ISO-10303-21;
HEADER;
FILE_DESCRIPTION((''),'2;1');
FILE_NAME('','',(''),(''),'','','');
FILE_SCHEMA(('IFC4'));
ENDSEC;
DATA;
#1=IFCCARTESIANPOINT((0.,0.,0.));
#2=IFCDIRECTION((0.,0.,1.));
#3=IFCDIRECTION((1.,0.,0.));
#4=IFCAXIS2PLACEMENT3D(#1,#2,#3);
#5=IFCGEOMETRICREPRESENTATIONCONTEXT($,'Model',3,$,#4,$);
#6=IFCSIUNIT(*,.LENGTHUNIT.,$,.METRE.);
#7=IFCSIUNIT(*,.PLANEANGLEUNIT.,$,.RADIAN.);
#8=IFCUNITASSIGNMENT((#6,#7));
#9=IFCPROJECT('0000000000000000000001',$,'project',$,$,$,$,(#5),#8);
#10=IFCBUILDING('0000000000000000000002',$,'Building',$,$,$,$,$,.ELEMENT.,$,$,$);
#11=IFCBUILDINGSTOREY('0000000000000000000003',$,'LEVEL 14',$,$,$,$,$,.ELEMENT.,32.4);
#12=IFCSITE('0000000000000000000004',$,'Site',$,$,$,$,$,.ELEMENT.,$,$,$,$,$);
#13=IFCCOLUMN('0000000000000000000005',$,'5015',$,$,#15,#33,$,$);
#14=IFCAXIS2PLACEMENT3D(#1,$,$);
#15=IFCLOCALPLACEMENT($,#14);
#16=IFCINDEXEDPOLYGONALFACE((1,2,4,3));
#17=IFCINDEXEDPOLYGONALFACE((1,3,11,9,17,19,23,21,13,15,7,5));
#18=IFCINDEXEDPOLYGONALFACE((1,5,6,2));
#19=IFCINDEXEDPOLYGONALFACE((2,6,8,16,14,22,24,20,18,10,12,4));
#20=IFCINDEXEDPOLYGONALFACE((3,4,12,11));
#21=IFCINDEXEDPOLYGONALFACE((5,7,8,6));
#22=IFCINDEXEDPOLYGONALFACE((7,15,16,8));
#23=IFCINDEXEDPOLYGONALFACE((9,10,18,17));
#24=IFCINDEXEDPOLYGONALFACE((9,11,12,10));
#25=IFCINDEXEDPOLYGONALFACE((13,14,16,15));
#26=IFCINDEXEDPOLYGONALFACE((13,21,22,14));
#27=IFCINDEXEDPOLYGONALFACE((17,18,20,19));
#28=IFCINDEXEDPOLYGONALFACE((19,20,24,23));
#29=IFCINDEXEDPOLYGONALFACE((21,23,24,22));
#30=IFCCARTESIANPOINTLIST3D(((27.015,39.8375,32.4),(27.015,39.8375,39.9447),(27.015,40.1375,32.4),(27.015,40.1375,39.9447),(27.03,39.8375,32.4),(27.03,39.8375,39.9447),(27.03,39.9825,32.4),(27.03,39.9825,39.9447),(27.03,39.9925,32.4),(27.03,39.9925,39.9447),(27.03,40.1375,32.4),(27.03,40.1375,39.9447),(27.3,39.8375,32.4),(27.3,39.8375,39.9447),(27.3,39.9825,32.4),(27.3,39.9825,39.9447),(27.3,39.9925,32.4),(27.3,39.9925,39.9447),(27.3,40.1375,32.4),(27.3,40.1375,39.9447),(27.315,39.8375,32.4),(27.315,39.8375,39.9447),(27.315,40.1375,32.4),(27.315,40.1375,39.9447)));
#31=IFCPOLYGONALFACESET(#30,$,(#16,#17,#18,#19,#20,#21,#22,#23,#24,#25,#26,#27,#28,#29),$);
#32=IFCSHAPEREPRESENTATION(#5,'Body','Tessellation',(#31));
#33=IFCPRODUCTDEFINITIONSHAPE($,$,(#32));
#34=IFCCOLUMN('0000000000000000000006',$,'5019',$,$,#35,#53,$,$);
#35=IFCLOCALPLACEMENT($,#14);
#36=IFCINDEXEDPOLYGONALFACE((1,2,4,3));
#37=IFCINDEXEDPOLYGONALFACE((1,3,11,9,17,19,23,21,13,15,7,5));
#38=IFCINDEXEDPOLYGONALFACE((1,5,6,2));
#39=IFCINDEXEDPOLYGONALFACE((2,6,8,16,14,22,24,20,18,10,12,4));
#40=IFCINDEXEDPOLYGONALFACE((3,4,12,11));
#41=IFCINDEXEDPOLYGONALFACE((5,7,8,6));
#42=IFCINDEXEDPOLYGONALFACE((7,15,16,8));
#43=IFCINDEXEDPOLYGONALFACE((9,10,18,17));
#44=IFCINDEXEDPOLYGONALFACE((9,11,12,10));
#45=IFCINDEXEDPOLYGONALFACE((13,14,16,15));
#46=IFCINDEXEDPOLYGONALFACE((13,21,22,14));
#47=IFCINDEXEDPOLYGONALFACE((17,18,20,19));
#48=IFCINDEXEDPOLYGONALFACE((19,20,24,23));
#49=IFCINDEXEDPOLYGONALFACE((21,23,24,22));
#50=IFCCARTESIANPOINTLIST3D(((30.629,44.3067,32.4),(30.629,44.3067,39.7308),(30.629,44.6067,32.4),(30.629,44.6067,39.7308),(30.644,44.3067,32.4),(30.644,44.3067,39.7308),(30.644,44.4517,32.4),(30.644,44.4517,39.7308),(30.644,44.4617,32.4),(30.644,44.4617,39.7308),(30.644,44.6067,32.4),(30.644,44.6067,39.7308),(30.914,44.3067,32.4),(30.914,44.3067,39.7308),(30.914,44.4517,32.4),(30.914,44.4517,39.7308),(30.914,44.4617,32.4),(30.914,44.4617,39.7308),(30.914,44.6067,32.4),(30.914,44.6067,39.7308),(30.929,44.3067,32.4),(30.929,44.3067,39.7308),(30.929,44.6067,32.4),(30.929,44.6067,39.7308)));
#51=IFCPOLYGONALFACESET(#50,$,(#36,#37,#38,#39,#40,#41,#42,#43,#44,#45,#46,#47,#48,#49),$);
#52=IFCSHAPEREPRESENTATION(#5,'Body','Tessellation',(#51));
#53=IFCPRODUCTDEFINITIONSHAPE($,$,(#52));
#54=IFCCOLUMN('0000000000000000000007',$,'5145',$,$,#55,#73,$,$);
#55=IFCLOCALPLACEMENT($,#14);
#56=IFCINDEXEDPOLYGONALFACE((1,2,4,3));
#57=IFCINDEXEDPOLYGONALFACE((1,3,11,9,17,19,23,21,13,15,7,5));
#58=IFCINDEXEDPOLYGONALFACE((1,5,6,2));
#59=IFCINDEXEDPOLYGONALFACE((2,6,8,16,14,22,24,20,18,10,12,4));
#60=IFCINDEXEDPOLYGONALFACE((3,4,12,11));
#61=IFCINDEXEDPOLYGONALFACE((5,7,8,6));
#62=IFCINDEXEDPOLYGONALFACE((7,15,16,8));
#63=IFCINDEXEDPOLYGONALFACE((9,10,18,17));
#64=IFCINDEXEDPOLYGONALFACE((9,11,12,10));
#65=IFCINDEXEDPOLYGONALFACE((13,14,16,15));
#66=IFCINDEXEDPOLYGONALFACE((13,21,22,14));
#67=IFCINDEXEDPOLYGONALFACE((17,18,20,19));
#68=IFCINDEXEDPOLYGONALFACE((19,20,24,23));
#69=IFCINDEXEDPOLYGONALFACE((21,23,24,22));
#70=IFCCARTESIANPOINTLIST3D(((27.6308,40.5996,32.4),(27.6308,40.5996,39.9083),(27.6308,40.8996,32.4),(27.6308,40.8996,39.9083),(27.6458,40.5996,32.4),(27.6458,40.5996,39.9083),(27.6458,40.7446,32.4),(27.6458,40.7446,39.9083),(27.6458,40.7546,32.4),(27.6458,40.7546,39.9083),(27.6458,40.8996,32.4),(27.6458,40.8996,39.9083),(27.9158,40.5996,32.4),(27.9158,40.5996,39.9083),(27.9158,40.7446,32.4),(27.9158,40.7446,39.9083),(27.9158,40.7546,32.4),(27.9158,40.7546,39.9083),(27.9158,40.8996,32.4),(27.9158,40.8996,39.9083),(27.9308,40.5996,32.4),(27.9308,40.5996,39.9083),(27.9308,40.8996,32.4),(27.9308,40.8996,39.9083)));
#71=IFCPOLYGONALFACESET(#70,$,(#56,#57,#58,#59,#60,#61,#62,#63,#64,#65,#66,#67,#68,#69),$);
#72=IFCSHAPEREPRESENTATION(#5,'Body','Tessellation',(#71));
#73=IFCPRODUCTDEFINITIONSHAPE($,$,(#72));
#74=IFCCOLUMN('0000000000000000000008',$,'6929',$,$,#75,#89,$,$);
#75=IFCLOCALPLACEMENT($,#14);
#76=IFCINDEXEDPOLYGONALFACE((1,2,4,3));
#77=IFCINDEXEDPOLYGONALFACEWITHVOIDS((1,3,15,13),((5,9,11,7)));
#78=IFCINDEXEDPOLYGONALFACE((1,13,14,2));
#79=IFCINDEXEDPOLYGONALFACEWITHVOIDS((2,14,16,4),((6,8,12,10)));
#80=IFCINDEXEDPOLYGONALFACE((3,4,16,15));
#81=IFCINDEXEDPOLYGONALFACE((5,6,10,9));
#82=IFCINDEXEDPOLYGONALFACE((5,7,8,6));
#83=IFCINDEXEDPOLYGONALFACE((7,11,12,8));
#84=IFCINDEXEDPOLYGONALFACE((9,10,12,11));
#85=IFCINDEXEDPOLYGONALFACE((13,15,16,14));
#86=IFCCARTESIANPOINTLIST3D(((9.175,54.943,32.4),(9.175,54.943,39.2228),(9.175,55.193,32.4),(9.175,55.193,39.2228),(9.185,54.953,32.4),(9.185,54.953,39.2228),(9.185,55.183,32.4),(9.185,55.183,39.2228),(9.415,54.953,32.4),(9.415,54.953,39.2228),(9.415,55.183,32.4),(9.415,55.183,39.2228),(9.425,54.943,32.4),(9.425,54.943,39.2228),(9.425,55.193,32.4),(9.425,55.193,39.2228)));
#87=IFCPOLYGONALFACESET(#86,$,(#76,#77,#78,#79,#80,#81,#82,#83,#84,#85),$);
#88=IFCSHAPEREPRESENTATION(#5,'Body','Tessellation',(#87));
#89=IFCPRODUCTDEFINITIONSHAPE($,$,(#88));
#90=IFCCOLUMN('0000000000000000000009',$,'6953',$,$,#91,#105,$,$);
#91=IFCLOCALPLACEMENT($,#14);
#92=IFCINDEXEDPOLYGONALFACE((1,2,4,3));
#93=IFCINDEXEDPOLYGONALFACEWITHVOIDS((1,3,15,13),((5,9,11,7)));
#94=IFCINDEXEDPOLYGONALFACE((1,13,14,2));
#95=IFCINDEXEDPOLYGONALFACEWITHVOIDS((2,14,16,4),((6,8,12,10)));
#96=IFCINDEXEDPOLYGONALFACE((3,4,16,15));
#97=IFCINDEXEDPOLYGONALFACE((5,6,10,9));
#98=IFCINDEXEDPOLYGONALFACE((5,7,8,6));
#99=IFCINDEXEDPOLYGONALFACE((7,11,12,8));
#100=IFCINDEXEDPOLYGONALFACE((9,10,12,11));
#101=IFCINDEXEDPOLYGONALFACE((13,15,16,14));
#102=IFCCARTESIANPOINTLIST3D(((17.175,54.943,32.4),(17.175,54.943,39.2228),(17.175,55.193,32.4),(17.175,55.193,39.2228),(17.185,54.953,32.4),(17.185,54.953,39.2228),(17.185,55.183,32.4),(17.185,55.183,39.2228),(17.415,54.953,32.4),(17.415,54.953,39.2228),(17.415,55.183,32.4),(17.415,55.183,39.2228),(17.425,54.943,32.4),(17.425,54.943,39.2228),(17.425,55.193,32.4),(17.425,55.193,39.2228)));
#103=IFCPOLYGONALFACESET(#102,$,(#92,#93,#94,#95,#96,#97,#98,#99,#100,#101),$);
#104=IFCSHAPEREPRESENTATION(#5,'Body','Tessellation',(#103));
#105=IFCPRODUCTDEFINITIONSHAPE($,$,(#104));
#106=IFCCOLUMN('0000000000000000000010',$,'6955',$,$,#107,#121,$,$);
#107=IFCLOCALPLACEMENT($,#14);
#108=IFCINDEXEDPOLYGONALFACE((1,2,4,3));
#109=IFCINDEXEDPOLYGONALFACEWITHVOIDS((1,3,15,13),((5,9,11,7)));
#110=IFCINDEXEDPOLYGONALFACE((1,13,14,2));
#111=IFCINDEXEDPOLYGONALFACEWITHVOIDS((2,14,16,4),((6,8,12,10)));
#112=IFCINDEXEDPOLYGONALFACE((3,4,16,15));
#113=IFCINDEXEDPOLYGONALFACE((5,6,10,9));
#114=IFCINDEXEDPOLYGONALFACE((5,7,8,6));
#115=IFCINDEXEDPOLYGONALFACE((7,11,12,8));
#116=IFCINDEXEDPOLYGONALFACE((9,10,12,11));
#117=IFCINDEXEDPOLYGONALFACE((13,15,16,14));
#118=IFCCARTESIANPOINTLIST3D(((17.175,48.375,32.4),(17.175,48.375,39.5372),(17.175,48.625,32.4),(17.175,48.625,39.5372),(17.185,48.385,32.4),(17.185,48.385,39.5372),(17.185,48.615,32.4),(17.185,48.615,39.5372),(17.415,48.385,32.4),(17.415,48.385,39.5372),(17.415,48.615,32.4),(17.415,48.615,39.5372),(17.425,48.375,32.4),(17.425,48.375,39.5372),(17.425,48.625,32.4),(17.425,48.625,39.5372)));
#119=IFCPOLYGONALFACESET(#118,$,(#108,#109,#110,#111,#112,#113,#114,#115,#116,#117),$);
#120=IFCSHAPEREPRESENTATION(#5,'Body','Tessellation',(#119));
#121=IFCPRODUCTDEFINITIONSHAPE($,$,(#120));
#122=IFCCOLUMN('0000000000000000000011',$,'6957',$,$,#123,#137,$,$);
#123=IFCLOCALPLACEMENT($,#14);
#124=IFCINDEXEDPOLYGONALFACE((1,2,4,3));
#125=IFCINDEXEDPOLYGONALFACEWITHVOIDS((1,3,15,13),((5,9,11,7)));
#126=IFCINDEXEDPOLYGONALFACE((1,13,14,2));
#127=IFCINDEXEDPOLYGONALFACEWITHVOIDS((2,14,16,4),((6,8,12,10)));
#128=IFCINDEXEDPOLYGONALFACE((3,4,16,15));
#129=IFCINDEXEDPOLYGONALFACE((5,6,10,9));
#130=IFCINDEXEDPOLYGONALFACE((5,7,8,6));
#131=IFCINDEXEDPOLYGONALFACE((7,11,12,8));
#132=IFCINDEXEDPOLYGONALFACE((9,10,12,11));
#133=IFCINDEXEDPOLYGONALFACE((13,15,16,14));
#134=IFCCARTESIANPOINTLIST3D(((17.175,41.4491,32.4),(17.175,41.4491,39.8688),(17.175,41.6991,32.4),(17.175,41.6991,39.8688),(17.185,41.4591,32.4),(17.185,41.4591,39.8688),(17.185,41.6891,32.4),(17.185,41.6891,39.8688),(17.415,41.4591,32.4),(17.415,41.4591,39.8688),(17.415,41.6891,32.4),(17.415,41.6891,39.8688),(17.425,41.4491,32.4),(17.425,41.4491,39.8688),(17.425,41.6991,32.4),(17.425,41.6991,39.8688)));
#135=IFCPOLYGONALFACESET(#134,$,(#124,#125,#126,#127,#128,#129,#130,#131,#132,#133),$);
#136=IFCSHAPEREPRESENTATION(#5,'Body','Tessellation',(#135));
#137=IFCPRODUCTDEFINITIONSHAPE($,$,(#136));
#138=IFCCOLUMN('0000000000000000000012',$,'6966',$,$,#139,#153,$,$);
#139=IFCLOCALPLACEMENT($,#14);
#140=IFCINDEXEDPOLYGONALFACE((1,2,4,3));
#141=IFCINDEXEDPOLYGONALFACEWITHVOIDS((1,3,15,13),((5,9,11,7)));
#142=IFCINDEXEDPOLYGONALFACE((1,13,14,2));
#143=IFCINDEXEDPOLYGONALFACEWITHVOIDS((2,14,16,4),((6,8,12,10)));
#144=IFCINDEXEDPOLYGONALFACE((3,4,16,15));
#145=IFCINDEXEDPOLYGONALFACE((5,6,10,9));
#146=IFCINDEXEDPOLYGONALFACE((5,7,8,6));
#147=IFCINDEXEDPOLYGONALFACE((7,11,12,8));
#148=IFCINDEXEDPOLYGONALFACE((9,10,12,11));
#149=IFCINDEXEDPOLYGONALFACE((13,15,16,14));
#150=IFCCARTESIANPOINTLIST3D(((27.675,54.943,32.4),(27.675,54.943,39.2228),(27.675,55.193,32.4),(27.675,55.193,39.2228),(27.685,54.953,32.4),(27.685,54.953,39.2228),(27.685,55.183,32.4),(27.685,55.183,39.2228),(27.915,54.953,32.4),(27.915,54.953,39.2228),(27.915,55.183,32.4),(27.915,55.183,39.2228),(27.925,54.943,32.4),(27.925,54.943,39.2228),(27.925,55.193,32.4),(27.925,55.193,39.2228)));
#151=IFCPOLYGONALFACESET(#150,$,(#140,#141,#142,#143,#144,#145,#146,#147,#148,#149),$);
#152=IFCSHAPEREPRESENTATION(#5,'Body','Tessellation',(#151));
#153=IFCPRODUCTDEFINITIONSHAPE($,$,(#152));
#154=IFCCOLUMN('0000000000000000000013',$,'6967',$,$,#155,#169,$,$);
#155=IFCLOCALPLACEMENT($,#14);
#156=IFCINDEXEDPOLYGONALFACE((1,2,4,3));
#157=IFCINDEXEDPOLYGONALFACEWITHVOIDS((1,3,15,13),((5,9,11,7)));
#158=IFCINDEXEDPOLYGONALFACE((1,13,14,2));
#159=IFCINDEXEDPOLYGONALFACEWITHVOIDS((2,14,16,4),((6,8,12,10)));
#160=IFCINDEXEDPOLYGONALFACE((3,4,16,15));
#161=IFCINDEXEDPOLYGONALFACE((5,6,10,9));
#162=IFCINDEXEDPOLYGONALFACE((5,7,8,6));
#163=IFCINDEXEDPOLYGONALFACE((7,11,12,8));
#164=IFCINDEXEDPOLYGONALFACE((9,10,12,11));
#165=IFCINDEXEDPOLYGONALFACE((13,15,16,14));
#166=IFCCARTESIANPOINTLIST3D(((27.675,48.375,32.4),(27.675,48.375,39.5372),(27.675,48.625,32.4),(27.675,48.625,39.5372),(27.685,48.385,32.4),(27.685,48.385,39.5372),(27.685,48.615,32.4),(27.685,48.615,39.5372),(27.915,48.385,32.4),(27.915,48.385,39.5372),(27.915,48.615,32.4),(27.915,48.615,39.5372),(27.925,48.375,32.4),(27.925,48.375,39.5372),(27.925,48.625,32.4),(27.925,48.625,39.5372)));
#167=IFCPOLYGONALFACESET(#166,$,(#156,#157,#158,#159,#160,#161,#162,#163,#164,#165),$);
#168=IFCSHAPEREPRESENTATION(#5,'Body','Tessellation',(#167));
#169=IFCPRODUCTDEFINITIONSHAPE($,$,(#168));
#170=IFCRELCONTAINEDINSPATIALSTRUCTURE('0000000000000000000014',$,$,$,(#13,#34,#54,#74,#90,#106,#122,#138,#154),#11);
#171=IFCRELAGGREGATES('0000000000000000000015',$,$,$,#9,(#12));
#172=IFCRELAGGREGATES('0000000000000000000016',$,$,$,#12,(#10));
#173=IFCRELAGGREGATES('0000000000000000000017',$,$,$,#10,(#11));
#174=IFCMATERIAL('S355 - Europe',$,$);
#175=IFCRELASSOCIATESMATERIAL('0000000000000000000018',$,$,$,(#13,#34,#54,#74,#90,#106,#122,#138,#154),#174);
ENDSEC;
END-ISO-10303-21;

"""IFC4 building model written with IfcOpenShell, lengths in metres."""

from ifc_helpers import new_model, si_unit, frame, origin_with_axes, origin_2d_with_axis, place, context, project, spatial, hollow_rectangle, i_section, extrude, material, material_profile, profile_set, profile_usage, element, save


model = new_model("IFC4")

# Units and contexts
model_context = context("Model", 3, world=origin_with_axes())
ifc_project = project(units=[si_unit("LENGTHUNIT", "METRE"), si_unit("PLANEANGLEUNIT", "RADIAN")], contexts=[model_context])

# Site, building, storey
site = spatial("IfcSite", under=ifc_project, Name="Site", CompositionType="ELEMENT")
building = spatial("IfcBuilding", under=site, Name="Building", CompositionType="ELEMENT")
storey = spatial("IfcBuildingStorey", under=building, Name="LEVEL 14", CompositionType="ELEMENT", Elevation=32.4)

# Columns
ifc_material = material(Name="S355 - Europe")
ifc_material_profile_1 = material_profile(ifc_material, i_section(OverallWidth=0.3, OverallDepth=0.3, WebThickness=0.01, FlangeThickness=0.015, at=origin_2d_with_axis()))
ifc_profile_set_1 = profile_set([ifc_material_profile_1])
ifc_profile_usage_1 = profile_usage(ifc_profile_set_1, cardinal=10)
column_1_placement = place(None, frame((27.165, 39.9875, 32.4), z_axis=(0.0, 0.0, 1.0), x_axis=(0.0, -1.0, 0.0)))
element("IfcColumn", 1, at=column_1_placement, inside=storey, material=ifc_profile_usage_1, Name="5015", context=model_context, shape_type="SweptSolid", body=[
    extrude(i_section(OverallWidth=0.3, OverallDepth=0.3, WebThickness=0.01, FlangeThickness=0.015, at=origin_2d_with_axis()), origin_with_axes(), (0.0, 0.0, 1.0), 7.5447),
])
ifc_material_profile_2 = material_profile(ifc_material, i_section(OverallWidth=0.3, OverallDepth=0.3, WebThickness=0.01, FlangeThickness=0.015, at=origin_2d_with_axis()))
ifc_profile_set_2 = profile_set([ifc_material_profile_2])
ifc_profile_usage_2 = profile_usage(ifc_profile_set_2, cardinal=10)
column_2_placement = place(None, frame((30.779, 44.4567, 32.4), z_axis=(0.0, 0.0, 1.0), x_axis=(0.0, -1.0, 0.0)))
element("IfcColumn", 2, at=column_2_placement, inside=storey, material=ifc_profile_usage_2, Name="5019", context=model_context, shape_type="SweptSolid", body=[
    extrude(i_section(OverallWidth=0.3, OverallDepth=0.3, WebThickness=0.01, FlangeThickness=0.015, at=origin_2d_with_axis()), origin_with_axes(), (0.0, 0.0, 1.0), 7.3308),
])
ifc_material_profile_3 = material_profile(ifc_material, i_section(OverallWidth=0.3, OverallDepth=0.3, WebThickness=0.01, FlangeThickness=0.015, at=origin_2d_with_axis()))
ifc_profile_set_3 = profile_set([ifc_material_profile_3])
ifc_profile_usage_3 = profile_usage(ifc_profile_set_3, cardinal=10)
column_3_placement = place(None, frame((27.7808, 40.7496, 32.4), z_axis=(0.0, 0.0, 1.0), x_axis=(0.0, -1.0, 0.0)))
element("IfcColumn", 3, at=column_3_placement, inside=storey, material=ifc_profile_usage_3, Name="5145", context=model_context, shape_type="SweptSolid", body=[
    extrude(i_section(OverallWidth=0.3, OverallDepth=0.3, WebThickness=0.01, FlangeThickness=0.015, at=origin_2d_with_axis()), origin_with_axes(), (0.0, 0.0, 1.0), 7.5083),
])
ifc_material_profile_4 = material_profile(ifc_material, hollow_rectangle(XDim=0.25, YDim=0.25, WallThickness=0.01, at=origin_2d_with_axis()))
ifc_profile_set_4 = profile_set([ifc_material_profile_4])
ifc_profile_usage_4 = profile_usage(ifc_profile_set_4, cardinal=10)
column_4_placement = place(None, frame((9.3, 55.068, 32.4), z_axis=(0.0, 0.0, 1.0), x_axis=(0.0, -1.0, 0.0)))
element("IfcColumn", 4, at=column_4_placement, inside=storey, material=ifc_profile_usage_4, Name="6929", context=model_context, shape_type="SweptSolid", body=[
    extrude(hollow_rectangle(XDim=0.25, YDim=0.25, WallThickness=0.01, at=origin_2d_with_axis()), origin_with_axes(), (0.0, 0.0, 1.0), 6.8228),
])
ifc_material_profile_5 = material_profile(ifc_material, hollow_rectangle(XDim=0.25, YDim=0.25, WallThickness=0.01, at=origin_2d_with_axis()))
ifc_profile_set_5 = profile_set([ifc_material_profile_5])
ifc_profile_usage_5 = profile_usage(ifc_profile_set_5, cardinal=10)
column_5_placement = place(None, frame((17.3, 55.068, 32.4), z_axis=(0.0, 0.0, 1.0), x_axis=(0.0, -1.0, 0.0)))
element("IfcColumn", 5, at=column_5_placement, inside=storey, material=ifc_profile_usage_5, Name="6953", context=model_context, shape_type="SweptSolid", body=[
    extrude(hollow_rectangle(XDim=0.25, YDim=0.25, WallThickness=0.01, at=origin_2d_with_axis()), origin_with_axes(), (0.0, 0.0, 1.0), 6.8228),
])
ifc_material_profile_6 = material_profile(ifc_material, hollow_rectangle(XDim=0.25, YDim=0.25, WallThickness=0.01, at=origin_2d_with_axis()))
ifc_profile_set_6 = profile_set([ifc_material_profile_6])
ifc_profile_usage_6 = profile_usage(ifc_profile_set_6, cardinal=10)
column_6_placement = place(None, frame((17.3, 48.5, 32.4), z_axis=(0.0, 0.0, 1.0), x_axis=(0.0, -1.0, 0.0)))
element("IfcColumn", 6, at=column_6_placement, inside=storey, material=ifc_profile_usage_6, Name="6955", context=model_context, shape_type="SweptSolid", body=[
    extrude(hollow_rectangle(XDim=0.25, YDim=0.25, WallThickness=0.01, at=origin_2d_with_axis()), origin_with_axes(), (0.0, 0.0, 1.0), 7.1372),
])
ifc_material_profile_7 = material_profile(ifc_material, hollow_rectangle(XDim=0.25, YDim=0.25, WallThickness=0.01, at=origin_2d_with_axis()))
ifc_profile_set_7 = profile_set([ifc_material_profile_7])
ifc_profile_usage_7 = profile_usage(ifc_profile_set_7, cardinal=10)
column_7_placement = place(None, frame((17.3, 41.5741, 32.4), z_axis=(0.0, 0.0, 1.0), x_axis=(0.0, -1.0, 0.0)))
element("IfcColumn", 7, at=column_7_placement, inside=storey, material=ifc_profile_usage_7, Name="6957", context=model_context, shape_type="SweptSolid", body=[
    extrude(hollow_rectangle(XDim=0.25, YDim=0.25, WallThickness=0.01, at=origin_2d_with_axis()), origin_with_axes(), (0.0, 0.0, 1.0), 7.4688),
])
ifc_material_profile_8 = material_profile(ifc_material, hollow_rectangle(XDim=0.25, YDim=0.25, WallThickness=0.01, at=origin_2d_with_axis()))
ifc_profile_set_8 = profile_set([ifc_material_profile_8])
ifc_profile_usage_8 = profile_usage(ifc_profile_set_8, cardinal=10)
column_8_placement = place(None, frame((27.8, 55.068, 32.4), z_axis=(0.0, 0.0, 1.0), x_axis=(0.0, -1.0, 0.0)))
element("IfcColumn", 8, at=column_8_placement, inside=storey, material=ifc_profile_usage_8, Name="6966", context=model_context, shape_type="SweptSolid", body=[
    extrude(hollow_rectangle(XDim=0.25, YDim=0.25, WallThickness=0.01, at=origin_2d_with_axis()), origin_with_axes(), (0.0, 0.0, 1.0), 6.8228),
])
ifc_material_profile_9 = material_profile(ifc_material, hollow_rectangle(XDim=0.25, YDim=0.25, WallThickness=0.01, at=origin_2d_with_axis()))
ifc_profile_set_9 = profile_set([ifc_material_profile_9])
ifc_profile_usage_9 = profile_usage(ifc_profile_set_9, cardinal=10)
column_9_placement = place(None, frame((27.8, 48.5, 32.4), z_axis=(0.0, 0.0, 1.0), x_axis=(0.0, -1.0, 0.0)))
element("IfcColumn", 9, at=column_9_placement, inside=storey, material=ifc_profile_usage_9, Name="6967", context=model_context, shape_type="SweptSolid", body=[
    extrude(hollow_rectangle(XDim=0.25, YDim=0.25, WallThickness=0.01, at=origin_2d_with_axis()), origin_with_axes(), (0.0, 0.0, 1.0), 7.1372),
])

save(model, "model.ifc")
